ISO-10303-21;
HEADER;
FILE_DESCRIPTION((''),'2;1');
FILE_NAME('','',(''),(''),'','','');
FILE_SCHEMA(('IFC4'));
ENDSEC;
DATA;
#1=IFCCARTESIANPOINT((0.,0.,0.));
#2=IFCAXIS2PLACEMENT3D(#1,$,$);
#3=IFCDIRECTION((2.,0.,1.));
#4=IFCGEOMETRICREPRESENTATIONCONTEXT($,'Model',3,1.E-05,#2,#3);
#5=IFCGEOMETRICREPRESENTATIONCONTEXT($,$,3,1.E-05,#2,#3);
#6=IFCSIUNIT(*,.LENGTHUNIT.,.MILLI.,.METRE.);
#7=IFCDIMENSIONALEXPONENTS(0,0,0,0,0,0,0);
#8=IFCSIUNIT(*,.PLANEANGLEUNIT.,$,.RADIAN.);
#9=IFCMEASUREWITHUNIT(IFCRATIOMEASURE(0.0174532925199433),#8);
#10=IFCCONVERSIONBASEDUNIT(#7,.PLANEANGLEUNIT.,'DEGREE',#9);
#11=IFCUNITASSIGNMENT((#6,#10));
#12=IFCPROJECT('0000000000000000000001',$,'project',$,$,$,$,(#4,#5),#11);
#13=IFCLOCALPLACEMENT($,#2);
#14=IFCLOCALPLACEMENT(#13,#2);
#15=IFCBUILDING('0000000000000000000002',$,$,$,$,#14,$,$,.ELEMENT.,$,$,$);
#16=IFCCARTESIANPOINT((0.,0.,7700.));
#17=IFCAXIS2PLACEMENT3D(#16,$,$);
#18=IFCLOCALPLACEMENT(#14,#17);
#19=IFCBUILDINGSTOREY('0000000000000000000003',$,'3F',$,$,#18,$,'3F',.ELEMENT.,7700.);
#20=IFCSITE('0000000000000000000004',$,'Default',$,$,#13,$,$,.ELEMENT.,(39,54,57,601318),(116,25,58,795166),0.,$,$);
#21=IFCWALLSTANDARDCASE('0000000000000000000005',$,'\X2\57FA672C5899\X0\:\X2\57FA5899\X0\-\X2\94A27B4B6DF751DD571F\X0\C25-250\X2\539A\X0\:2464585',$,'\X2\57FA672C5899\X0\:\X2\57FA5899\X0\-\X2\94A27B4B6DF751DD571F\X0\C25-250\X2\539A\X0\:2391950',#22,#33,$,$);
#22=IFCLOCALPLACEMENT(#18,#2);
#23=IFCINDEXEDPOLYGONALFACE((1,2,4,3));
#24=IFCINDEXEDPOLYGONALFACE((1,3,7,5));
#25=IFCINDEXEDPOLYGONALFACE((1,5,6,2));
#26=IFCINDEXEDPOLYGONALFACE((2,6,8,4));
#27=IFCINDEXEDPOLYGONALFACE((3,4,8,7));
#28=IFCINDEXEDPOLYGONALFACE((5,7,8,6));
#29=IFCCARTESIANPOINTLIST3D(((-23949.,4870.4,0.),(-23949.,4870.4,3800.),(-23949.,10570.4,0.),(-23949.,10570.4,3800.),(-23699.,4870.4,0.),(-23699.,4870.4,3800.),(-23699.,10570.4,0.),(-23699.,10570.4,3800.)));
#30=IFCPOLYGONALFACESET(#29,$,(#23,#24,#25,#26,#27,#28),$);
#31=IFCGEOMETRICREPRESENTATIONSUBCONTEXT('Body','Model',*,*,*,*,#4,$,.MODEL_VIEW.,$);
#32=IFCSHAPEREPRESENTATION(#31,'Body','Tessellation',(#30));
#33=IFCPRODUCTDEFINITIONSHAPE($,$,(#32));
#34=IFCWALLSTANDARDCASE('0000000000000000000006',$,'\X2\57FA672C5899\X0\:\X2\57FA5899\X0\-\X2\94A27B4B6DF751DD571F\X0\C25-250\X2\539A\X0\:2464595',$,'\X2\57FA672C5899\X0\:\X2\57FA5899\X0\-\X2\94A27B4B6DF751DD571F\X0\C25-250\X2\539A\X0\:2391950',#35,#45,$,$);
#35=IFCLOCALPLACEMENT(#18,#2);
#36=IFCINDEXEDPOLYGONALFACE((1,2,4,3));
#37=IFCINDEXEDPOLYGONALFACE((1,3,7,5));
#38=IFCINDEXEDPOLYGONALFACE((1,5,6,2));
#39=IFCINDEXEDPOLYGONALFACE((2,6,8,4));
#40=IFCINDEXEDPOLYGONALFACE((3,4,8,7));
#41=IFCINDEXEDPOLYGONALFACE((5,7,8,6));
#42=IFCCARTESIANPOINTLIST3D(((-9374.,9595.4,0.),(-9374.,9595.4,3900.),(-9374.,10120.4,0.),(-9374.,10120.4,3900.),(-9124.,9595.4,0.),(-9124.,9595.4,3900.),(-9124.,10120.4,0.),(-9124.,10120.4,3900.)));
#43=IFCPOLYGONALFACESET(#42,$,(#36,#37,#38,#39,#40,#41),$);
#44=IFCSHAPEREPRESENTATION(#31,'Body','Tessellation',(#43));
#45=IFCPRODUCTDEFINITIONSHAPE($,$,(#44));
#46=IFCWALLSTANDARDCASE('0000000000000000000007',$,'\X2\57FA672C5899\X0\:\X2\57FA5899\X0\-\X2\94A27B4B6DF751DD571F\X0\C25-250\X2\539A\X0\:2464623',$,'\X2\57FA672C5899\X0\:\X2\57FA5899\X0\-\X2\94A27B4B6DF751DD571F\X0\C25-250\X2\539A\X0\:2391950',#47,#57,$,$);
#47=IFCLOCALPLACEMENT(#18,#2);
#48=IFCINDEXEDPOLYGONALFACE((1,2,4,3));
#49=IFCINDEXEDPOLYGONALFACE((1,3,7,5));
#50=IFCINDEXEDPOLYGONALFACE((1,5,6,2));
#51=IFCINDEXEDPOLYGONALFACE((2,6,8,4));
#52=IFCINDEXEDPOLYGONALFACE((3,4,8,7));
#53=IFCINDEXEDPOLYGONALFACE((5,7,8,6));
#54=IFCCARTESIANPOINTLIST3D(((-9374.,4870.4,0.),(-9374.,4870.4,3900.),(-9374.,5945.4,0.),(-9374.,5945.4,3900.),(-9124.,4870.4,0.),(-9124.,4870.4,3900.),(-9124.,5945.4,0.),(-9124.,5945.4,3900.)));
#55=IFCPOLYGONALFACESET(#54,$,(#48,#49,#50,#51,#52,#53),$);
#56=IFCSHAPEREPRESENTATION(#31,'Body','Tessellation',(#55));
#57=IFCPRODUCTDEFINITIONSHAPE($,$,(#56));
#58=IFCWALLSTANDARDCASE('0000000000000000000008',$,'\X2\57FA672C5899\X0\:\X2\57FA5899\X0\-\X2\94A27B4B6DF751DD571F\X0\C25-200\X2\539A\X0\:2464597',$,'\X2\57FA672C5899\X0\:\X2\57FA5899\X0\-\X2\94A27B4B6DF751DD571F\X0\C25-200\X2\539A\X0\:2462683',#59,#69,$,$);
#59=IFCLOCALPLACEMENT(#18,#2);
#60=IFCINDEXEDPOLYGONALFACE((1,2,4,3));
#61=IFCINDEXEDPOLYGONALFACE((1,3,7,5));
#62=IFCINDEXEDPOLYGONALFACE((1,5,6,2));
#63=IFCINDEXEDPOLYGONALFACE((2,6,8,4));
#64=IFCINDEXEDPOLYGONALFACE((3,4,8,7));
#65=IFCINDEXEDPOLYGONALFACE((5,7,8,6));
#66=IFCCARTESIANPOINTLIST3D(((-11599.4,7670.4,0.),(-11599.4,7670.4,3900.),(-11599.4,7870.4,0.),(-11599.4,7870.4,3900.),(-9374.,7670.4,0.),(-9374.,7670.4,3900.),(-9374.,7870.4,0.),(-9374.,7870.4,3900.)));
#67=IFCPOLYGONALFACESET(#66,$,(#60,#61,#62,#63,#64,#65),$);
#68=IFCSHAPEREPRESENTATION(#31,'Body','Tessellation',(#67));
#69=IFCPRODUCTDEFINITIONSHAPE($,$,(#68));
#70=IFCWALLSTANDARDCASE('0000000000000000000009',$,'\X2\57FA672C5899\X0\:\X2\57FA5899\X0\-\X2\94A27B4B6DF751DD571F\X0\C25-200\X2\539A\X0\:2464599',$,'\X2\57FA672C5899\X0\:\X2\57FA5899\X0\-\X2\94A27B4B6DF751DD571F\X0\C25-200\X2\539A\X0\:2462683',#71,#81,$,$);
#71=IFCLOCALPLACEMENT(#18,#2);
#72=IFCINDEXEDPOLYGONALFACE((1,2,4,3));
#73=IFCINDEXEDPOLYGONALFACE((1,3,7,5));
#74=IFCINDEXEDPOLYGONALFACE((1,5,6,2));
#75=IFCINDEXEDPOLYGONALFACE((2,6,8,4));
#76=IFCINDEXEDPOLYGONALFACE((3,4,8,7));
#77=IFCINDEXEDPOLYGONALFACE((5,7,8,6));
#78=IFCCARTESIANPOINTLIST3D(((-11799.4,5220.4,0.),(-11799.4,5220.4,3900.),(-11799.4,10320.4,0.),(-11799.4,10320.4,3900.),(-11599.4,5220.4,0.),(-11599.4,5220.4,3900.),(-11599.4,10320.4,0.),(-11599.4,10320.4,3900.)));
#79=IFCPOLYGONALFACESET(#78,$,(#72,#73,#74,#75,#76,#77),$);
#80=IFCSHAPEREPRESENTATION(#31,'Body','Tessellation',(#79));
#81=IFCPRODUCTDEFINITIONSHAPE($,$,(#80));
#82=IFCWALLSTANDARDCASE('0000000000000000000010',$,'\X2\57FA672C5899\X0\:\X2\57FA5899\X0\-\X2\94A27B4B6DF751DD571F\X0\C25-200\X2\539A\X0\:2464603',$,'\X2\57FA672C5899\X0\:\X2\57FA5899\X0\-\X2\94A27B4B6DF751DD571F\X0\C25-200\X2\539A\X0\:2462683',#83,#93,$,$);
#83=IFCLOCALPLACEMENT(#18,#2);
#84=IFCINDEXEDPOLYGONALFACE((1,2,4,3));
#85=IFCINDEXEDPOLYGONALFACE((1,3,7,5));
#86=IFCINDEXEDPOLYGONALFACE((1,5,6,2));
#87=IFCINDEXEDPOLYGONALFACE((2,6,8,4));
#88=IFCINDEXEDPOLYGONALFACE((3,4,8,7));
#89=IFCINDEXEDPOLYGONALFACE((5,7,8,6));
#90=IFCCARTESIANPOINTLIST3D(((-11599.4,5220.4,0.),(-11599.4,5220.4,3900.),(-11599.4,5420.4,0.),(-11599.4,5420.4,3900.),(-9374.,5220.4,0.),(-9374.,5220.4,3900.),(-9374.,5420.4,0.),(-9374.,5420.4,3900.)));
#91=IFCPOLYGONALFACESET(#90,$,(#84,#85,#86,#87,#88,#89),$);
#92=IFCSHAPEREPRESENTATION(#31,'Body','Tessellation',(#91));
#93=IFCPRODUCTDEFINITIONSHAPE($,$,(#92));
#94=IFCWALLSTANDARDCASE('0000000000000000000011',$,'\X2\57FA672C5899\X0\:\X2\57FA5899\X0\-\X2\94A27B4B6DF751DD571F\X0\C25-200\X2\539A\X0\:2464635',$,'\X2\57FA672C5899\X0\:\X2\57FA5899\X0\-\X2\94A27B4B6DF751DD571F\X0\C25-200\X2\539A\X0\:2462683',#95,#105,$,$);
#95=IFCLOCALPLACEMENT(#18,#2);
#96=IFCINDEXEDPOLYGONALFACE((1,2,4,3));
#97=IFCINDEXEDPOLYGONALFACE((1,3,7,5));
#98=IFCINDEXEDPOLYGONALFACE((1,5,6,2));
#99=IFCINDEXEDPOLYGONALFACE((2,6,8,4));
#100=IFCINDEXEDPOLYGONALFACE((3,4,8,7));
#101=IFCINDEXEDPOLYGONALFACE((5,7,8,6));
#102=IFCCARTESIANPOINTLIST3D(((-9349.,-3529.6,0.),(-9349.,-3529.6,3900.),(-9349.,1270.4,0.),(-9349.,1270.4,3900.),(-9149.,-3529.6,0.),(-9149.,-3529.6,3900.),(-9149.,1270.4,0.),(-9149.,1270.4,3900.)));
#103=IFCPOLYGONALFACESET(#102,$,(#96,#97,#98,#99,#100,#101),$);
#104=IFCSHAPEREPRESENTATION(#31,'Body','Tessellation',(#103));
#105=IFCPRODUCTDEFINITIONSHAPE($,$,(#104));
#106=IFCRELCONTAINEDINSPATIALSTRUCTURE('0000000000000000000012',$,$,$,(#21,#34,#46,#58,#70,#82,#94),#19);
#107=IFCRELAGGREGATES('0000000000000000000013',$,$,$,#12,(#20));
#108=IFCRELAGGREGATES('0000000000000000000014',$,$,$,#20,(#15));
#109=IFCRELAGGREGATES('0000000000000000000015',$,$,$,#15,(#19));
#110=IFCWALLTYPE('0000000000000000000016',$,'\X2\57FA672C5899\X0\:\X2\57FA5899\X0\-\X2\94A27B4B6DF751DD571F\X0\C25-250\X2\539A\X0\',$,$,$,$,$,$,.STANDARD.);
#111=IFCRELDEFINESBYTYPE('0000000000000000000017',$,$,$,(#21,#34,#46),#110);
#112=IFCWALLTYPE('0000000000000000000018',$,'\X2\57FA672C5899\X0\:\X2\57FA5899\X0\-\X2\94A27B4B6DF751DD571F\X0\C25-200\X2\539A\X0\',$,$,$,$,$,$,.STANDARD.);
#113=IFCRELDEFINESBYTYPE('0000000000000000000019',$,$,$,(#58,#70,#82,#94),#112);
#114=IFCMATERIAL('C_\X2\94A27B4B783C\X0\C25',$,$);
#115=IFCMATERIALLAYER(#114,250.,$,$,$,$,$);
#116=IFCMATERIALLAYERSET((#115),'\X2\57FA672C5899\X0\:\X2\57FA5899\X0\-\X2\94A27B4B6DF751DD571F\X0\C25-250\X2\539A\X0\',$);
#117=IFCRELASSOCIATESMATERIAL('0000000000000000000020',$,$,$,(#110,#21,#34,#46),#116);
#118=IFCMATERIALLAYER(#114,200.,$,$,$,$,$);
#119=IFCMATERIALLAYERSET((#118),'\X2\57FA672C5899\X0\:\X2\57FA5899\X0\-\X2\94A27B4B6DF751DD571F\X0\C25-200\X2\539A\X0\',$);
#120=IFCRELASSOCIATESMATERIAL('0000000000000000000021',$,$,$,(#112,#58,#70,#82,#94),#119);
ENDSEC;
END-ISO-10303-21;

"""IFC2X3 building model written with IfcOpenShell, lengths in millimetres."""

from ifc_helpers import new_model, entity, si_unit, converted_unit, direction, frame, frame_2d, origin, place, context, subcontext, project, spatial, polyline, rectangle, extrude, clip, bounded_halfspace, material, layer, layer_set, layer_usage, type_object, element, save


model = new_model("IFC2X3")

# Units and contexts
model_context = context("Model", 3, precision=1e-05, world=origin(), true_north=direction((2.0, 0.0, 1.0)))
context_of_model = context(None, 3, precision=1e-05, world=origin(), true_north=direction((2.0, 0.0, 1.0)))
body_context = subcontext(model_context, "Body", "Model", "MODEL_VIEW")
ifc_project = project(units=[si_unit("LENGTHUNIT", "METRE", prefix="MILLI"), converted_unit("PLANEANGLEUNIT", "DEGREE", entity("IfcRatioMeasure", 0.0174532925199433), si_unit("PLANEANGLEUNIT", "RADIAN"), dimensions=[0, 0, 0, 0, 0, 0, 0])], contexts=[model_context, context_of_model])

# Site, building, storey
site_placement = place(None, origin())
site = spatial("IfcSite", under=ifc_project, at=site_placement, Name="Default", CompositionType="ELEMENT", RefLatitude=(39, 54, 57, 601318), RefLongitude=(116, 25, 58, 795166), RefElevation=0.0)
building_placement = place(site_placement, origin())
building = spatial("IfcBuilding", under=site, at=building_placement, CompositionType="ELEMENT")
storey_placement = place(building_placement, frame((0.0, 0.0, 7700.0)))
storey = spatial("IfcBuildingStorey", under=building, at=storey_placement, Name="3F", LongName="3F", CompositionType="ELEMENT", Elevation=7700.0)

# Shared definitions
ifc_material = material(Name="C_钢筋砼C25")

# Walls
ifc_layer_1 = layer(ifc_material, 250.0)
ifc_layer_set_1 = layer_set([ifc_layer_1], Name="基本墙:基墙-钢筋混凝土C25-250厚")
wall_type_1 = type_object("IfcWallType", Name="基本墙:基墙-钢筋混凝土C25-250厚", PredefinedType="STANDARD", material=ifc_layer_set_1)
ifc_layer_usage_1 = layer_usage(ifc_layer_set_1, "AXIS2", "NEGATIVE", 125.0)
wall_1_placement = place(storey_placement, frame((-23824.0, 4870.4, 0.0), z_axis=(0.0, 0.0, 1.0), x_axis=(0.0, 1.0, 0.0)))
element("IfcWallStandardCase", 1, at=wall_1_placement, inside=storey, type_object=wall_type_1, material=ifc_layer_usage_1, Name="基本墙:基墙-钢筋混凝土C25-250厚:2464585", ObjectType="基本墙:基墙-钢筋混凝土C25-250厚:2391950", context=body_context, shape_type="Clipping", body=[
    clip(clip(clip(extrude(rectangle(XDim=5700.0, YDim=250.0, at=frame_2d((2850.0, 0.0), x_axis=(-1.0, 0.0))), origin(), (0.0, 0.0, 1.0), 3900.0), bounded_halfspace(frame((0.0, 125.0, 0.0), z_axis=(1.0, 0.0, 0.0), x_axis=(0.0, 0.0, -1.0)), True, frame((0.0, 125.0, 0.0), z_axis=(1.0, 0.0, 0.0), x_axis=(0.0, 0.0, -1.0)), polyline([(0.0, 0.0), (-3800.0, 0.0), (-3800.0, -250.0), (0.0, -250.0), (0.0, 0.0)]))), bounded_halfspace(frame((5700.0, -125.0, 0.0), z_axis=(-1.0, 0.0, 0.0), x_axis=(0.0, 0.0, -1.0)), True, frame((5700.0, -125.0, 0.0), z_axis=(-1.0, 0.0, 0.0), x_axis=(0.0, 0.0, -1.0)), polyline([(0.0, 0.0), (-3800.0, 0.0), (-3800.0, -250.0), (0.0, -250.0), (0.0, 0.0)]))), bounded_halfspace(frame((0.0, -125.0, 3800.0), z_axis=(0.0, 0.0, -1.0), x_axis=(1.0, 0.0, 0.0)), True, frame((0.0, -125.0, 3800.0), z_axis=(0.0, 0.0, -1.0), x_axis=(1.0, 0.0, 0.0)), polyline([(0.0, 0.0), (0.0, -250.0), (5700.0, -250.0), (5700.0, 0.0), (0.0, 0.0)]))),
])
ifc_layer_usage_2 = layer_usage(ifc_layer_set_1, "AXIS2", "NEGATIVE", 125.0)
wall_2_placement = place(storey_placement, frame((-9249.0, 10120.4, 0.0), z_axis=(0.0, 0.0, 1.0), x_axis=(0.0, -1.0, 0.0)))
element("IfcWallStandardCase", 2, at=wall_2_placement, inside=storey, type_object=wall_type_1, material=ifc_layer_usage_2, Name="基本墙:基墙-钢筋混凝土C25-250厚:2464595", ObjectType="基本墙:基墙-钢筋混凝土C25-250厚:2391950", context=body_context, shape_type="SweptSolid", body=[
    extrude(rectangle(XDim=525.0, YDim=250.0, at=frame_2d((262.5, 0.0), x_axis=(-1.0, 0.0))), origin(), (0.0, 0.0, 1.0), 3900.0),
])
ifc_layer_usage_3 = layer_usage(ifc_layer_set_1, "AXIS2", "NEGATIVE", 125.0)
wall_3_placement = place(storey_placement, frame((-9249.0, 5945.4, 0.0), z_axis=(0.0, 0.0, 1.0), x_axis=(0.0, -1.0, 0.0)))
element("IfcWallStandardCase", 3, at=wall_3_placement, inside=storey, type_object=wall_type_1, material=ifc_layer_usage_3, Name="基本墙:基墙-钢筋混凝土C25-250厚:2464623", ObjectType="基本墙:基墙-钢筋混凝土C25-250厚:2391950", context=body_context, shape_type="Clipping", body=[
    clip(extrude(rectangle(XDim=1075.0, YDim=250.0, at=frame_2d((537.5, 0.0), x_axis=(-1.0, 0.0))), origin(), (0.0, 0.0, 1.0), 3900.0), bounded_halfspace(frame((1075.0, -125.0, 3900.0), z_axis=(-1.0, 0.0, 0.0), x_axis=(0.0, 0.0, -1.0)), True, frame((1075.0, -125.0, 3900.0), z_axis=(-1.0, 0.0, 0.0), x_axis=(0.0, 0.0, -1.0)), polyline([(0.0, 0.0), (0.0, -250.0), (100.0, -250.0), (3900.0, -250.0), (3900.0, 0.0), (100.0, 0.0), (0.0, 0.0)]))),
])
ifc_layer_2 = layer(ifc_material, 200.0)
ifc_layer_set_2 = layer_set([ifc_layer_2], Name="基本墙:基墙-钢筋混凝土C25-200厚")
ifc_layer_usage_4 = layer_usage(ifc_layer_set_2, "AXIS2", "NEGATIVE", 100.0)
wall_type_2 = type_object("IfcWallType", Name="基本墙:基墙-钢筋混凝土C25-200厚", PredefinedType="STANDARD", material=ifc_layer_set_2)
wall_4_placement = place(storey_placement, frame((-9374.0, 7770.4, 0.0), z_axis=(0.0, 0.0, 1.0), x_axis=(-1.0, 0.0, 0.0)))
element("IfcWallStandardCase", 4, at=wall_4_placement, inside=storey, type_object=wall_type_2, material=ifc_layer_usage_4, Name="基本墙:基墙-钢筋混凝土C25-200厚:2464597", ObjectType="基本墙:基墙-钢筋混凝土C25-200厚:2462683", context=body_context, shape_type="SweptSolid", body=[
    extrude(rectangle(XDim=2225.4, YDim=200.0, at=frame_2d((1112.7, 0.0), x_axis=(-1.0, 0.0))), origin(), (0.0, 0.0, 1.0), 3900.0),
])
ifc_layer_usage_5 = layer_usage(ifc_layer_set_2, "AXIS2", "NEGATIVE", 100.0)
wall_5_placement = place(storey_placement, frame((-11699.4, 10320.4, 0.0), z_axis=(0.0, 0.0, 1.0), x_axis=(0.0, -1.0, 0.0)))
element("IfcWallStandardCase", 5, at=wall_5_placement, inside=storey, type_object=wall_type_2, material=ifc_layer_usage_5, Name="基本墙:基墙-钢筋混凝土C25-200厚:2464599", ObjectType="基本墙:基墙-钢筋混凝土C25-200厚:2462683", context=body_context, shape_type="SweptSolid", body=[
    extrude(rectangle(XDim=5100.0, YDim=200.0, at=frame_2d((2550.0, 0.0), x_axis=(-1.0, 0.0))), origin(), (0.0, 0.0, 1.0), 3900.0),
])
ifc_layer_usage_6 = layer_usage(ifc_layer_set_2, "AXIS2", "NEGATIVE", 100.0)
wall_6_placement = place(storey_placement, frame((-9374.0, 5320.4, 0.0), z_axis=(0.0, 0.0, 1.0), x_axis=(-1.0, 0.0, 0.0)))
element("IfcWallStandardCase", 6, at=wall_6_placement, inside=storey, type_object=wall_type_2, material=ifc_layer_usage_6, Name="基本墙:基墙-钢筋混凝土C25-200厚:2464603", ObjectType="基本墙:基墙-钢筋混凝土C25-200厚:2462683", context=body_context, shape_type="SweptSolid", body=[
    extrude(rectangle(XDim=2225.4, YDim=200.0, at=frame_2d((1112.7, 0.0), x_axis=(-1.0, 0.0))), origin(), (0.0, 0.0, 1.0), 3900.0),
])
ifc_layer_usage_7 = layer_usage(ifc_layer_set_2, "AXIS2", "NEGATIVE", 100.0)
wall_7_placement = place(storey_placement, frame((-9249.0, 1270.4, 0.0), z_axis=(0.0, 0.0, 1.0), x_axis=(0.0, -1.0, 0.0)))
element("IfcWallStandardCase", 7, at=wall_7_placement, inside=storey, type_object=wall_type_2, material=ifc_layer_usage_7, Name="基本墙:基墙-钢筋混凝土C25-200厚:2464635", ObjectType="基本墙:基墙-钢筋混凝土C25-200厚:2462683", context=body_context, shape_type="Clipping", body=[
    clip(clip(extrude(rectangle(XDim=4800.0, YDim=200.0, at=frame_2d((2400.0, 0.0), x_axis=(-1.0, 0.0))), origin(), (0.0, 0.0, 1.0), 3900.0), bounded_halfspace(frame((0.0, -100.0, 0.0), z_axis=(1.0, 0.0, 0.0), x_axis=(0.0, 0.0, -1.0)), True, frame((0.0, -100.0, 0.0), z_axis=(1.0, 0.0, 0.0), x_axis=(0.0, 0.0, -1.0)), polyline([(0.0, 0.0), (0.0, 200.0), (-3900.0, 200.0), (-3900.0, 0.0), (0.0, 0.0)]))), bounded_halfspace(frame((4800.0, -100.0, 3900.0), z_axis=(-1.0, 0.0, 0.0), x_axis=(0.0, 0.0, -1.0)), True, frame((4800.0, -100.0, 3900.0), z_axis=(-1.0, 0.0, 0.0), x_axis=(0.0, 0.0, -1.0)), polyline([(0.0, 0.0), (0.0, -200.0), (3900.0, -200.0), (3900.0, 0.0), (0.0, 0.0)]))),
])

save(model, "model.ifc")
